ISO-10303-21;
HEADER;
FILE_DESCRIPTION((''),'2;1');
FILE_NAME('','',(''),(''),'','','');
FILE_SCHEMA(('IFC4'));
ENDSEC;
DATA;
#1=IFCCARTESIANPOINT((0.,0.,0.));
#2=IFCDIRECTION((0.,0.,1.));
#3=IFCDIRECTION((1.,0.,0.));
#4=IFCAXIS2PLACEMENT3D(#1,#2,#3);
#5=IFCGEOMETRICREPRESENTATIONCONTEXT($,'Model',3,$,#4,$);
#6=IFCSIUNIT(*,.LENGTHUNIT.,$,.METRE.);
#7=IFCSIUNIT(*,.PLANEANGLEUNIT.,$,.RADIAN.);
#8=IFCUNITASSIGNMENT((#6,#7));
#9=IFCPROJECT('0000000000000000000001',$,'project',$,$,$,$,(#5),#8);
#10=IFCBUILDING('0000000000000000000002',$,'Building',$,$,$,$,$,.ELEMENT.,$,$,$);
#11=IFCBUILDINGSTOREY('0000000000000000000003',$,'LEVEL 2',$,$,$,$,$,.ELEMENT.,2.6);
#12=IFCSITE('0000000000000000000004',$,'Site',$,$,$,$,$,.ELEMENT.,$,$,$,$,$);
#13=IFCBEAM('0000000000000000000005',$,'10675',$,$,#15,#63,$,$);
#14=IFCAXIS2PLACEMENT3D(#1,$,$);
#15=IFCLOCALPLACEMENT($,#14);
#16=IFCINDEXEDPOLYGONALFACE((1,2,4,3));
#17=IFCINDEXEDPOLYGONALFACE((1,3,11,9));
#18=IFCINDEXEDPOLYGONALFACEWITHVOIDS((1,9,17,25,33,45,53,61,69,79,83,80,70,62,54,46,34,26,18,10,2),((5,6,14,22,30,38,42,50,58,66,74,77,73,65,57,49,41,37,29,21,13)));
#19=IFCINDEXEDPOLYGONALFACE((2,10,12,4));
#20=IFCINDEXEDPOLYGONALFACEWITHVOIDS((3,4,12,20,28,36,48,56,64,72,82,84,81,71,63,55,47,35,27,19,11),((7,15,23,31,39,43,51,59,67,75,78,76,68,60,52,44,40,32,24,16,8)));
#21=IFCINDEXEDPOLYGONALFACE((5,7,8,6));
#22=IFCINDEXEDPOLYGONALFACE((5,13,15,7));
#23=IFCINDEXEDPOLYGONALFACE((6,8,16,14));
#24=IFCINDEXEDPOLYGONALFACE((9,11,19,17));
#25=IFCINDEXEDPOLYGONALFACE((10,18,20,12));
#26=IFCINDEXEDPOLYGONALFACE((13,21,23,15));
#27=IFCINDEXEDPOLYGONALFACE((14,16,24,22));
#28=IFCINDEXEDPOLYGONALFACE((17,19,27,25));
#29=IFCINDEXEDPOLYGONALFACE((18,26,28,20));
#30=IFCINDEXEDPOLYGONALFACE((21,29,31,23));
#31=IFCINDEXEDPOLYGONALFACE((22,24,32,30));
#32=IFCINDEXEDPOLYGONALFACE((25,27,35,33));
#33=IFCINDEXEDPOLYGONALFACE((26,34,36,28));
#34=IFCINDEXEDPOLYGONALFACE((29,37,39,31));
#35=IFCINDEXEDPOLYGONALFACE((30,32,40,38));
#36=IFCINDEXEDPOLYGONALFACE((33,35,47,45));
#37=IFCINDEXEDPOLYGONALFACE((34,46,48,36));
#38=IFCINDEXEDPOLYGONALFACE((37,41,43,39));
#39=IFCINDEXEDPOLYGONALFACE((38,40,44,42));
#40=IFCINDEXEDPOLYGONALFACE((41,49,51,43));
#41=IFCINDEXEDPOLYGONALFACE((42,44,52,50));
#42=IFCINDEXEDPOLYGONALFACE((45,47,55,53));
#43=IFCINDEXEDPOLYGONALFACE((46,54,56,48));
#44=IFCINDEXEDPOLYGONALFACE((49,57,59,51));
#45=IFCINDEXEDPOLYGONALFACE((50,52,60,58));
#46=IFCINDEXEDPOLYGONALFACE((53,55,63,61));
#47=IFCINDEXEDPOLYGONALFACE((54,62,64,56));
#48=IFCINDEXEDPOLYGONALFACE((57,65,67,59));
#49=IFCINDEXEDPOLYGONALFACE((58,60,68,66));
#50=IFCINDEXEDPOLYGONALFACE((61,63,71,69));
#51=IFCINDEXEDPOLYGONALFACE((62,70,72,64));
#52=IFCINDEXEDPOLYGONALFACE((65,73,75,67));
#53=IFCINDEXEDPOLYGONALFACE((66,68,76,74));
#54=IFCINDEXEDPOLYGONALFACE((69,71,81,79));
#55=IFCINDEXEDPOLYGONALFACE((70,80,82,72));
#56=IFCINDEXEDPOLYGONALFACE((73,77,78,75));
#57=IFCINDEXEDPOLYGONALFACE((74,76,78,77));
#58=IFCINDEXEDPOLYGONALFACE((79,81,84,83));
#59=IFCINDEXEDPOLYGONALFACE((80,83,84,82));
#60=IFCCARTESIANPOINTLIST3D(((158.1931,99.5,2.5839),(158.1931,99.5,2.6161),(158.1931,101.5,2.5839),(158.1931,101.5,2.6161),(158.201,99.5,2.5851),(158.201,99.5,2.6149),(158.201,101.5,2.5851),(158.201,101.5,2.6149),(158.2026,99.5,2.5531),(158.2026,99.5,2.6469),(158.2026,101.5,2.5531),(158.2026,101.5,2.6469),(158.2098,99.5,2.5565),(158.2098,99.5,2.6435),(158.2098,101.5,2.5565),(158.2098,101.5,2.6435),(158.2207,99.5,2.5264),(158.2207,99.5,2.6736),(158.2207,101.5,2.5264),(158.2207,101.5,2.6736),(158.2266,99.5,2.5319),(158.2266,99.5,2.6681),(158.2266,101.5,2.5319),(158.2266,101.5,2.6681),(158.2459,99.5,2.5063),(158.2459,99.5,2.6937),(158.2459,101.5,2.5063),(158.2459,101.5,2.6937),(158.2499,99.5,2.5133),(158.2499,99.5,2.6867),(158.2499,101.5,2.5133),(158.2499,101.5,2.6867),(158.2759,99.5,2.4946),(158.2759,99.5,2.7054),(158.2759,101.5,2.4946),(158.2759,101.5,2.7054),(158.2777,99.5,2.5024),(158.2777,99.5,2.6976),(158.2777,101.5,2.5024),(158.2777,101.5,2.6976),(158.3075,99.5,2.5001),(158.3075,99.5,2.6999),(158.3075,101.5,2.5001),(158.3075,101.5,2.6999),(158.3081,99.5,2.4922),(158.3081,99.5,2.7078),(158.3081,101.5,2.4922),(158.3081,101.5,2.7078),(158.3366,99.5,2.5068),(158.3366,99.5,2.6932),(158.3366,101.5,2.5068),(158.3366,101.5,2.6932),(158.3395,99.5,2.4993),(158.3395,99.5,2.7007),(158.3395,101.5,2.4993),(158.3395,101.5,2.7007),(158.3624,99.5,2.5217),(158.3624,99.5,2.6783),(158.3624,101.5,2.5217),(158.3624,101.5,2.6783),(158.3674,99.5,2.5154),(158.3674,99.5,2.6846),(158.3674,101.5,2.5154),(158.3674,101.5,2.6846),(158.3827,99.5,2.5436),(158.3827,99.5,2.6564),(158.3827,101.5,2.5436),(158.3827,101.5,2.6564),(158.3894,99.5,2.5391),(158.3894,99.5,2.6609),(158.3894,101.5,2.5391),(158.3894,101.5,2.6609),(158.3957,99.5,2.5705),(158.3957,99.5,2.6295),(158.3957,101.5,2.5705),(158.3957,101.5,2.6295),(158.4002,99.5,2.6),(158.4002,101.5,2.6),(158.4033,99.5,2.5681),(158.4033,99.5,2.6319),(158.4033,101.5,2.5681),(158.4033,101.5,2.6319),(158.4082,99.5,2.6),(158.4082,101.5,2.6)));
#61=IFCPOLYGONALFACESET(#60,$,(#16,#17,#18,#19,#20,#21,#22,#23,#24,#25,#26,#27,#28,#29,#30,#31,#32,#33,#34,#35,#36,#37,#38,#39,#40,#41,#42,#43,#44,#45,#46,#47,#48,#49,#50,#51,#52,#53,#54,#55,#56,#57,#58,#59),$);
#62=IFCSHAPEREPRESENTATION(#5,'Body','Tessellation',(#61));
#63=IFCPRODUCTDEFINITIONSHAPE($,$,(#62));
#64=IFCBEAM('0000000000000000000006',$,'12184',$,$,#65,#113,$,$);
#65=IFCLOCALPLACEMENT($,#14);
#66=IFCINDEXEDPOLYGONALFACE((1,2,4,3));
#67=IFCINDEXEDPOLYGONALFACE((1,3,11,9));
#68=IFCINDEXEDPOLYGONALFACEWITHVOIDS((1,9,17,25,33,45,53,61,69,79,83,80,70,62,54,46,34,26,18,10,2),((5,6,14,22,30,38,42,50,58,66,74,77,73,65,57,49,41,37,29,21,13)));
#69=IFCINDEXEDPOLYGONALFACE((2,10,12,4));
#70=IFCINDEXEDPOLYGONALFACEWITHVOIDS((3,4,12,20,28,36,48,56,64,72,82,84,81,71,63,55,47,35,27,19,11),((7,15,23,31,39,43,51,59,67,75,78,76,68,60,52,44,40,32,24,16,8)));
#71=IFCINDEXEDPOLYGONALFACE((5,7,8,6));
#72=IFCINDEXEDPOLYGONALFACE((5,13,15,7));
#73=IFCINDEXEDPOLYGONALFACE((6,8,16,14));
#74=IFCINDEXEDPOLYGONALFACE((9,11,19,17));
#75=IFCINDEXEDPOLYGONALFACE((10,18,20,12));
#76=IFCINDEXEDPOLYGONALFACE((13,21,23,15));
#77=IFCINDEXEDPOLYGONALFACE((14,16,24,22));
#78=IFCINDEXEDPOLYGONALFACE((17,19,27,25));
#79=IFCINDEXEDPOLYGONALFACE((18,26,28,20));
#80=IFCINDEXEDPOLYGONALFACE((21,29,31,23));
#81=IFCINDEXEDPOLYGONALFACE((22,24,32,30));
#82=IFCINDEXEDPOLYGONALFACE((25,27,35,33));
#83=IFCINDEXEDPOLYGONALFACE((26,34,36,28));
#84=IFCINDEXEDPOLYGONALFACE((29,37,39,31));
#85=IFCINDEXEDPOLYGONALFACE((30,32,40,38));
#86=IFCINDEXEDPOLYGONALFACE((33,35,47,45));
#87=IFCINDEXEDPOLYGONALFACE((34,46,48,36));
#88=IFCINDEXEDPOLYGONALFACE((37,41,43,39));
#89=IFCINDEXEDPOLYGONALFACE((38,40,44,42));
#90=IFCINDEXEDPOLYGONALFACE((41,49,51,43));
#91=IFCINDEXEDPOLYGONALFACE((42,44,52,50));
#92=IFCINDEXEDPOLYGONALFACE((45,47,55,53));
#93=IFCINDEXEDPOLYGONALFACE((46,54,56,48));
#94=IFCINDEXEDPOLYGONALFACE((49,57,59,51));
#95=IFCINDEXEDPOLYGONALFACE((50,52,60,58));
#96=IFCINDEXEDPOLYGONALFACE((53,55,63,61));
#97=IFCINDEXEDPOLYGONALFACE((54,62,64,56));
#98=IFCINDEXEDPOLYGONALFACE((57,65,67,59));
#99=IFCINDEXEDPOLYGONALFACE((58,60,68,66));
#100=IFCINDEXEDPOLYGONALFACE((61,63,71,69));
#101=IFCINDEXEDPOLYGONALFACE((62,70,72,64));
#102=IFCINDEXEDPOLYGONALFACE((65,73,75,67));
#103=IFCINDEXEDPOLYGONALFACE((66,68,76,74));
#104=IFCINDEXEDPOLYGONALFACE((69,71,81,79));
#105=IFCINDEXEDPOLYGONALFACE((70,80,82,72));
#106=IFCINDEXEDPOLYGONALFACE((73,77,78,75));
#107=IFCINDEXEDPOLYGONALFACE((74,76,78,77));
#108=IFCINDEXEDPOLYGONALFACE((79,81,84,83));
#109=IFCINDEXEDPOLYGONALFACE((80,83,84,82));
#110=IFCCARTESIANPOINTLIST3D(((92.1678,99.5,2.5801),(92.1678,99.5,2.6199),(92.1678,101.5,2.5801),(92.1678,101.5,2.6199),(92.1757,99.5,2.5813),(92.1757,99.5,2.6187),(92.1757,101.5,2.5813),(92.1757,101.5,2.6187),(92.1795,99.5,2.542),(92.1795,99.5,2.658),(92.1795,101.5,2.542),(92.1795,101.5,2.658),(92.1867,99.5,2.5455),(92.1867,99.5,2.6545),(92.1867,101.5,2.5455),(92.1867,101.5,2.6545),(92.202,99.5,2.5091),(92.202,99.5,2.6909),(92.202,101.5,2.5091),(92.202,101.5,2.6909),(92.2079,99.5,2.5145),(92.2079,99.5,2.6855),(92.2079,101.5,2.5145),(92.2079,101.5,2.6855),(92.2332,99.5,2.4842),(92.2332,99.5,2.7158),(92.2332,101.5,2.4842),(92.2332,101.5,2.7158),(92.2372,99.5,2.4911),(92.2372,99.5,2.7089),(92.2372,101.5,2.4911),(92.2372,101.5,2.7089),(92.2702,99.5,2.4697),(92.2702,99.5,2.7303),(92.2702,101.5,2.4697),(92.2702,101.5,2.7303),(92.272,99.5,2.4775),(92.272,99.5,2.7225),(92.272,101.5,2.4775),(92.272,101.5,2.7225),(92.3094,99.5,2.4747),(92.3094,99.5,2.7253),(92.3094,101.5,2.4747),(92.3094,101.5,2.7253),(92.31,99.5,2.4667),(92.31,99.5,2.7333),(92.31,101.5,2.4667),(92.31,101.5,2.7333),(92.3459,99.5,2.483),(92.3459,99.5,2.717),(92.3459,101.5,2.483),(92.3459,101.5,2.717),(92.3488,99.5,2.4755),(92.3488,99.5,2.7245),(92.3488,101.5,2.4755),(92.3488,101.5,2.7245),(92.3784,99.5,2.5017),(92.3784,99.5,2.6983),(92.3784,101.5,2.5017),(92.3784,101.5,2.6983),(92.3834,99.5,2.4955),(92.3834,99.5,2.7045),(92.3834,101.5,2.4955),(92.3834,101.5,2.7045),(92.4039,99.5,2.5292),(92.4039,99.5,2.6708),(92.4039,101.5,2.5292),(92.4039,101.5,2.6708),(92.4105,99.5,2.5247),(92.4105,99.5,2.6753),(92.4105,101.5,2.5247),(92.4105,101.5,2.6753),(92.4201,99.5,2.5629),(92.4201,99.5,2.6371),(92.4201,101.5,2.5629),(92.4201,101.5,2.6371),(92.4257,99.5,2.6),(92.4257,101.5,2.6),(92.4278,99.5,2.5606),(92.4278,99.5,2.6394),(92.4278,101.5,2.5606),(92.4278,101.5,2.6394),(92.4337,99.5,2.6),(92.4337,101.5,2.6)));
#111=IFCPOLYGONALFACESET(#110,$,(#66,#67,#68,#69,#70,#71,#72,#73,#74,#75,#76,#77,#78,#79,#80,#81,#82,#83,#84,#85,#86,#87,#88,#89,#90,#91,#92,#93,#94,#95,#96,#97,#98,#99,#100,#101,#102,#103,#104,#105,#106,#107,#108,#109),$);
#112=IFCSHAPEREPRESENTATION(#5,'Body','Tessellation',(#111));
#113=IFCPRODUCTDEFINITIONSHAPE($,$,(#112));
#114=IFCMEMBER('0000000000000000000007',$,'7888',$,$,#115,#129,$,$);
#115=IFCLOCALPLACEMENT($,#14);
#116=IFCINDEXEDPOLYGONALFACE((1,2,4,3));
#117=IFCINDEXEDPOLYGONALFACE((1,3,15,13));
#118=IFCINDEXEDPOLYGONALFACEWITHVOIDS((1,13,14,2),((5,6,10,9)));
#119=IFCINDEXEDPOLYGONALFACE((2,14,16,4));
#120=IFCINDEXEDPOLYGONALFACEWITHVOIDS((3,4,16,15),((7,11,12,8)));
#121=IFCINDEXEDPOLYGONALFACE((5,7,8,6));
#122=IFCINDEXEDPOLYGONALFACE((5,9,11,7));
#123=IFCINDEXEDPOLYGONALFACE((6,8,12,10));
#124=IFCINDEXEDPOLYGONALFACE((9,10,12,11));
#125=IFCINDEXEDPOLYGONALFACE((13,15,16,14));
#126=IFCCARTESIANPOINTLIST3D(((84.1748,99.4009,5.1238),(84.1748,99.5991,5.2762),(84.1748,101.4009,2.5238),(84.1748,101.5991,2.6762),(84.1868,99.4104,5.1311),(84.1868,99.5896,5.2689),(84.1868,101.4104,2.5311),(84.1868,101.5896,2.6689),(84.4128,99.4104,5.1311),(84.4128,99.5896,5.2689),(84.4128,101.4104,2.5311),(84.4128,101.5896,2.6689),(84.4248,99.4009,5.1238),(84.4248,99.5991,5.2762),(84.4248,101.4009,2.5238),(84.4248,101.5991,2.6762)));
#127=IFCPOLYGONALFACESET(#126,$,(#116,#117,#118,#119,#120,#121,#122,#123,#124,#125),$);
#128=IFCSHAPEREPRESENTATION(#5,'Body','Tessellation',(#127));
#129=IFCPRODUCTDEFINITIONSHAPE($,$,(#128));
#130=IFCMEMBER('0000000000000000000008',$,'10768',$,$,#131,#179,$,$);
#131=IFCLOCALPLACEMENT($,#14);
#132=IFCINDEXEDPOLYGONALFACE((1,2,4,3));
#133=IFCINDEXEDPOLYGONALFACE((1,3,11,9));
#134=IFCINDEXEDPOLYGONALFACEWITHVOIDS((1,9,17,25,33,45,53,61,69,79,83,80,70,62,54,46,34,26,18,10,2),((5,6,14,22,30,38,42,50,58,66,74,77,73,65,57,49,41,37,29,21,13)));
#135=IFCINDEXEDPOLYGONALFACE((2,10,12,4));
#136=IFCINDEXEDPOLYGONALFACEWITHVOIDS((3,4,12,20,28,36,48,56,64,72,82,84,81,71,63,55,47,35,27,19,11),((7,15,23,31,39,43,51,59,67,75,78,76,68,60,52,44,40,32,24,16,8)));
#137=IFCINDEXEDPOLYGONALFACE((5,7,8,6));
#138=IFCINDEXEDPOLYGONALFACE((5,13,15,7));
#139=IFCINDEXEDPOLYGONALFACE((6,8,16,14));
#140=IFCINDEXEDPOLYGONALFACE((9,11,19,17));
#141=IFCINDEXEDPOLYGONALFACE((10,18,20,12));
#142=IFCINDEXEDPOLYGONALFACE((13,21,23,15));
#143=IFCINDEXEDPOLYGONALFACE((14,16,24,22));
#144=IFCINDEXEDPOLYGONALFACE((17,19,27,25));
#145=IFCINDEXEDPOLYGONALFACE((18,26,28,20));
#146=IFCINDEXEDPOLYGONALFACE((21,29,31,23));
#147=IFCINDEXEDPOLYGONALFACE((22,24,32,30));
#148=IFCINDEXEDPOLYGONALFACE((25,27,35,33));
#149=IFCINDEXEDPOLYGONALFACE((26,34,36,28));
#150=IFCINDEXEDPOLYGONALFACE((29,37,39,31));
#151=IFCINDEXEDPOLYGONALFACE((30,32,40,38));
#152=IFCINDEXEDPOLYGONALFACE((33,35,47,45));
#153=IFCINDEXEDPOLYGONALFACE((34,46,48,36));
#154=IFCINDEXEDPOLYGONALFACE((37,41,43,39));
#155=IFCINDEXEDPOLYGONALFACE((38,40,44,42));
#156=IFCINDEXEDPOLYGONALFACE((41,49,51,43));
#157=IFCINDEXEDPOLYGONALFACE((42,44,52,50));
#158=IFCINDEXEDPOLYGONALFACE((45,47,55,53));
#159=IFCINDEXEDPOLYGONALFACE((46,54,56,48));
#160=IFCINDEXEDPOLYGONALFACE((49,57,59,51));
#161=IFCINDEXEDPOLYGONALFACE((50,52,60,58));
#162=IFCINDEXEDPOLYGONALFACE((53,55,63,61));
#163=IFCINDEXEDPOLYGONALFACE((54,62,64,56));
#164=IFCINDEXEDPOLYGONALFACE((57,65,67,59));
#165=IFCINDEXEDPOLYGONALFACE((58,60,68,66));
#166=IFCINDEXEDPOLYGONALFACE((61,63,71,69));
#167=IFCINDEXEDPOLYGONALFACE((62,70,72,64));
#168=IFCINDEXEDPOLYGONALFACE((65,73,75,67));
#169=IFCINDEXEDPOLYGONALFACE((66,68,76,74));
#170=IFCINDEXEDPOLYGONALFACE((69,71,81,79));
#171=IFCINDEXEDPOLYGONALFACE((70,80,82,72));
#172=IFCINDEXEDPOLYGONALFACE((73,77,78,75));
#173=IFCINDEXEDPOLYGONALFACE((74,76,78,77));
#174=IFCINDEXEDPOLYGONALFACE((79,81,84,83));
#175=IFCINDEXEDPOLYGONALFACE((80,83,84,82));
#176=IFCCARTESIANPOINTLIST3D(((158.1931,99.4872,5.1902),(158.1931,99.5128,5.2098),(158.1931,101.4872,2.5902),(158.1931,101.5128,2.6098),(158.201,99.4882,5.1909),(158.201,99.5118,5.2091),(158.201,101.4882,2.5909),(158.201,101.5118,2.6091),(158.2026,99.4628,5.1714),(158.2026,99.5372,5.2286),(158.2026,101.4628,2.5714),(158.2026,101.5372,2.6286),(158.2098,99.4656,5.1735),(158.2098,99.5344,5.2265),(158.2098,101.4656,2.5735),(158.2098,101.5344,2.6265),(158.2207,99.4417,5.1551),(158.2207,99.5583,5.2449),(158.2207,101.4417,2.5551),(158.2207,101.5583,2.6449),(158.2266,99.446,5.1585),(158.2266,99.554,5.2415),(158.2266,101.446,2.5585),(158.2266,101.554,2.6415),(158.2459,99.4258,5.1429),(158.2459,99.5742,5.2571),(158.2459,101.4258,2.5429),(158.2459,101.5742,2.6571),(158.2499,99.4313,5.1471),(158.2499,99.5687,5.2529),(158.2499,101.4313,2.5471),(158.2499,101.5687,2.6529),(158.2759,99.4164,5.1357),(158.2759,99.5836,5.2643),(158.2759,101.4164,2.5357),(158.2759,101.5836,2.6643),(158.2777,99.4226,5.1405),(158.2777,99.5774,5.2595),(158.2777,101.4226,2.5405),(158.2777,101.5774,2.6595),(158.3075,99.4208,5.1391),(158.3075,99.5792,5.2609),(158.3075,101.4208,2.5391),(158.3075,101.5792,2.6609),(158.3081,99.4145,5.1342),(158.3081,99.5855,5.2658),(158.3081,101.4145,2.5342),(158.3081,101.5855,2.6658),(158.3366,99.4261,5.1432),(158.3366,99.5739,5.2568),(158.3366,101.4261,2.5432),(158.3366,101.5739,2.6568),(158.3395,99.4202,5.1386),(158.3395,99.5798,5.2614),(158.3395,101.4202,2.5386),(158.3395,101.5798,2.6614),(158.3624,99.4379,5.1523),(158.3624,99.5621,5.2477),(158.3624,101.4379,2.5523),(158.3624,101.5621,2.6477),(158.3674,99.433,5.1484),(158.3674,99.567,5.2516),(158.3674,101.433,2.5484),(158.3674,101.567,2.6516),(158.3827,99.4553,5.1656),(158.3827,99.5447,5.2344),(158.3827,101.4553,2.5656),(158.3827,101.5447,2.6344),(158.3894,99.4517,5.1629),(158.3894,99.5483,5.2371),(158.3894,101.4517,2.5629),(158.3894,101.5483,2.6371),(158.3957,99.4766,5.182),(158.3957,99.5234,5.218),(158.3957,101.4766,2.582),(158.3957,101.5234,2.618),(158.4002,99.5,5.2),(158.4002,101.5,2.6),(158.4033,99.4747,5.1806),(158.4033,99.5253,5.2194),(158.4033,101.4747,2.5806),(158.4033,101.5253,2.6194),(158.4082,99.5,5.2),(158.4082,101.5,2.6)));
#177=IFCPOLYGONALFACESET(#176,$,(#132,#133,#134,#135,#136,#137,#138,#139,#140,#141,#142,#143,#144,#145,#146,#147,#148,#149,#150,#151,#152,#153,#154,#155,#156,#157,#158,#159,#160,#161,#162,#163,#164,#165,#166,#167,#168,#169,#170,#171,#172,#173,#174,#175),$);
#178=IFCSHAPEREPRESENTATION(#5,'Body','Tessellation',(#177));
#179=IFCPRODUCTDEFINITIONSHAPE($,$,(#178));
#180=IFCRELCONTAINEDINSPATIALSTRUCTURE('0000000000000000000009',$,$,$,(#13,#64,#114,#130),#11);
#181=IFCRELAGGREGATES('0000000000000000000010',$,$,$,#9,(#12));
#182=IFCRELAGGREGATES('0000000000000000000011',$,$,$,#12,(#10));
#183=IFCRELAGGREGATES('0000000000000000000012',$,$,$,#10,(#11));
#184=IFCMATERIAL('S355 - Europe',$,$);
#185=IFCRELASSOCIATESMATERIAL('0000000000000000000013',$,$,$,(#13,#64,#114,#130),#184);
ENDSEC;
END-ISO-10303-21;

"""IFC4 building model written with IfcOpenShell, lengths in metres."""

from ifc_helpers import new_model, si_unit, frame, origin_with_axes, origin_2d_with_axis, place, context, project, spatial, hollow_rectangle, hollow_circle, extrude, material, material_profile, profile_set, profile_usage, element, save


model = new_model("IFC4")

# Units and contexts
model_context = context("Model", 3, world=origin_with_axes())
ifc_project = project(units=[si_unit("LENGTHUNIT", "METRE"), si_unit("PLANEANGLEUNIT", "RADIAN")], contexts=[model_context])

# Site, building, storey
site = spatial("IfcSite", under=ifc_project, Name="Site", CompositionType="ELEMENT")
building = spatial("IfcBuilding", under=site, Name="Building", CompositionType="ELEMENT")
storey = spatial("IfcBuildingStorey", under=building, Name="LEVEL 2", CompositionType="ELEMENT", Elevation=2.6)

# Shared definitions
ifc_material = material(Name="S355 - Europe")

# Beams
ifc_material_profile_1 = material_profile(ifc_material, hollow_circle(Radius=0.1081, WallThickness=0.008, at=origin_2d_with_axis()))
ifc_profile_set_1 = profile_set([ifc_material_profile_1])
ifc_profile_usage_1 = profile_usage(ifc_profile_set_1, cardinal=10)
beam_1_placement = place(None, frame((158.3, 101.5, 2.6), z_axis=(0.0, -1.0, 0.0), x_axis=(1.0, 0.0, 0.0)))
element("IfcBeam", 1, at=beam_1_placement, inside=storey, material=ifc_profile_usage_1, Name="10675", context=model_context, shape_type="SweptSolid", body=[
    extrude(hollow_circle(Radius=0.1081, WallThickness=0.008, at=origin_2d_with_axis()), origin_with_axes(), (0.0, 0.0, 1.0), 2.0),
])
ifc_material_profile_2 = material_profile(ifc_material, hollow_circle(Radius=0.1337, WallThickness=0.008, at=origin_2d_with_axis()))
ifc_profile_set_2 = profile_set([ifc_material_profile_2])
ifc_profile_usage_2 = profile_usage(ifc_profile_set_2, cardinal=10)
beam_2_placement = place(None, frame((92.3, 101.5, 2.6), z_axis=(0.0, -1.0, 0.0), x_axis=(1.0, 0.0, 0.0)))
element("IfcBeam", 2, at=beam_2_placement, inside=storey, material=ifc_profile_usage_2, Name="12184", context=model_context, shape_type="SweptSolid", body=[
    extrude(hollow_circle(Radius=0.1337, WallThickness=0.008, at=origin_2d_with_axis()), origin_with_axes(), (0.0, 0.0, 1.0), 2.0),
])

# Members
ifc_material_profile_3 = material_profile(ifc_material, hollow_rectangle(XDim=0.25, YDim=0.25, WallThickness=0.012, at=origin_2d_with_axis()))
ifc_profile_set_3 = profile_set([ifc_material_profile_3])
ifc_profile_usage_3 = profile_usage(ifc_profile_set_3, cardinal=10)
member_1_placement = place(None, frame((84.2998, 101.5, 2.6), z_axis=(0.0, -0.609711, 0.792624), x_axis=(1.0, 0.0, 0.0)))
element("IfcMember", 3, at=member_1_placement, inside=storey, material=ifc_profile_usage_3, Name="7888", context=model_context, shape_type="SweptSolid", body=[
    extrude(hollow_rectangle(XDim=0.25, YDim=0.25, WallThickness=0.012, at=origin_2d_with_axis()), origin_with_axes(), (0.0, 0.0, 1.0), 3.2802),
])
ifc_material_profile_4 = material_profile(ifc_material, hollow_circle(Radius=0.1081, WallThickness=0.008, at=origin_2d_with_axis()))
ifc_profile_set_4 = profile_set([ifc_material_profile_4])
ifc_profile_usage_4 = profile_usage(ifc_profile_set_4, cardinal=10)
member_2_placement = place(None, frame((158.3, 101.5, 2.6), z_axis=(0.0, -0.609711, 0.792624), x_axis=(1.0, 0.0, 0.0)))
element("IfcMember", 4, at=member_2_placement, inside=storey, material=ifc_profile_usage_4, Name="10768", context=model_context, shape_type="SweptSolid", body=[
    extrude(hollow_circle(Radius=0.1081, WallThickness=0.008, at=origin_2d_with_axis()), origin_with_axes(), (0.0, 0.0, 1.0), 3.2802),
])

save(model, "model.ifc")
